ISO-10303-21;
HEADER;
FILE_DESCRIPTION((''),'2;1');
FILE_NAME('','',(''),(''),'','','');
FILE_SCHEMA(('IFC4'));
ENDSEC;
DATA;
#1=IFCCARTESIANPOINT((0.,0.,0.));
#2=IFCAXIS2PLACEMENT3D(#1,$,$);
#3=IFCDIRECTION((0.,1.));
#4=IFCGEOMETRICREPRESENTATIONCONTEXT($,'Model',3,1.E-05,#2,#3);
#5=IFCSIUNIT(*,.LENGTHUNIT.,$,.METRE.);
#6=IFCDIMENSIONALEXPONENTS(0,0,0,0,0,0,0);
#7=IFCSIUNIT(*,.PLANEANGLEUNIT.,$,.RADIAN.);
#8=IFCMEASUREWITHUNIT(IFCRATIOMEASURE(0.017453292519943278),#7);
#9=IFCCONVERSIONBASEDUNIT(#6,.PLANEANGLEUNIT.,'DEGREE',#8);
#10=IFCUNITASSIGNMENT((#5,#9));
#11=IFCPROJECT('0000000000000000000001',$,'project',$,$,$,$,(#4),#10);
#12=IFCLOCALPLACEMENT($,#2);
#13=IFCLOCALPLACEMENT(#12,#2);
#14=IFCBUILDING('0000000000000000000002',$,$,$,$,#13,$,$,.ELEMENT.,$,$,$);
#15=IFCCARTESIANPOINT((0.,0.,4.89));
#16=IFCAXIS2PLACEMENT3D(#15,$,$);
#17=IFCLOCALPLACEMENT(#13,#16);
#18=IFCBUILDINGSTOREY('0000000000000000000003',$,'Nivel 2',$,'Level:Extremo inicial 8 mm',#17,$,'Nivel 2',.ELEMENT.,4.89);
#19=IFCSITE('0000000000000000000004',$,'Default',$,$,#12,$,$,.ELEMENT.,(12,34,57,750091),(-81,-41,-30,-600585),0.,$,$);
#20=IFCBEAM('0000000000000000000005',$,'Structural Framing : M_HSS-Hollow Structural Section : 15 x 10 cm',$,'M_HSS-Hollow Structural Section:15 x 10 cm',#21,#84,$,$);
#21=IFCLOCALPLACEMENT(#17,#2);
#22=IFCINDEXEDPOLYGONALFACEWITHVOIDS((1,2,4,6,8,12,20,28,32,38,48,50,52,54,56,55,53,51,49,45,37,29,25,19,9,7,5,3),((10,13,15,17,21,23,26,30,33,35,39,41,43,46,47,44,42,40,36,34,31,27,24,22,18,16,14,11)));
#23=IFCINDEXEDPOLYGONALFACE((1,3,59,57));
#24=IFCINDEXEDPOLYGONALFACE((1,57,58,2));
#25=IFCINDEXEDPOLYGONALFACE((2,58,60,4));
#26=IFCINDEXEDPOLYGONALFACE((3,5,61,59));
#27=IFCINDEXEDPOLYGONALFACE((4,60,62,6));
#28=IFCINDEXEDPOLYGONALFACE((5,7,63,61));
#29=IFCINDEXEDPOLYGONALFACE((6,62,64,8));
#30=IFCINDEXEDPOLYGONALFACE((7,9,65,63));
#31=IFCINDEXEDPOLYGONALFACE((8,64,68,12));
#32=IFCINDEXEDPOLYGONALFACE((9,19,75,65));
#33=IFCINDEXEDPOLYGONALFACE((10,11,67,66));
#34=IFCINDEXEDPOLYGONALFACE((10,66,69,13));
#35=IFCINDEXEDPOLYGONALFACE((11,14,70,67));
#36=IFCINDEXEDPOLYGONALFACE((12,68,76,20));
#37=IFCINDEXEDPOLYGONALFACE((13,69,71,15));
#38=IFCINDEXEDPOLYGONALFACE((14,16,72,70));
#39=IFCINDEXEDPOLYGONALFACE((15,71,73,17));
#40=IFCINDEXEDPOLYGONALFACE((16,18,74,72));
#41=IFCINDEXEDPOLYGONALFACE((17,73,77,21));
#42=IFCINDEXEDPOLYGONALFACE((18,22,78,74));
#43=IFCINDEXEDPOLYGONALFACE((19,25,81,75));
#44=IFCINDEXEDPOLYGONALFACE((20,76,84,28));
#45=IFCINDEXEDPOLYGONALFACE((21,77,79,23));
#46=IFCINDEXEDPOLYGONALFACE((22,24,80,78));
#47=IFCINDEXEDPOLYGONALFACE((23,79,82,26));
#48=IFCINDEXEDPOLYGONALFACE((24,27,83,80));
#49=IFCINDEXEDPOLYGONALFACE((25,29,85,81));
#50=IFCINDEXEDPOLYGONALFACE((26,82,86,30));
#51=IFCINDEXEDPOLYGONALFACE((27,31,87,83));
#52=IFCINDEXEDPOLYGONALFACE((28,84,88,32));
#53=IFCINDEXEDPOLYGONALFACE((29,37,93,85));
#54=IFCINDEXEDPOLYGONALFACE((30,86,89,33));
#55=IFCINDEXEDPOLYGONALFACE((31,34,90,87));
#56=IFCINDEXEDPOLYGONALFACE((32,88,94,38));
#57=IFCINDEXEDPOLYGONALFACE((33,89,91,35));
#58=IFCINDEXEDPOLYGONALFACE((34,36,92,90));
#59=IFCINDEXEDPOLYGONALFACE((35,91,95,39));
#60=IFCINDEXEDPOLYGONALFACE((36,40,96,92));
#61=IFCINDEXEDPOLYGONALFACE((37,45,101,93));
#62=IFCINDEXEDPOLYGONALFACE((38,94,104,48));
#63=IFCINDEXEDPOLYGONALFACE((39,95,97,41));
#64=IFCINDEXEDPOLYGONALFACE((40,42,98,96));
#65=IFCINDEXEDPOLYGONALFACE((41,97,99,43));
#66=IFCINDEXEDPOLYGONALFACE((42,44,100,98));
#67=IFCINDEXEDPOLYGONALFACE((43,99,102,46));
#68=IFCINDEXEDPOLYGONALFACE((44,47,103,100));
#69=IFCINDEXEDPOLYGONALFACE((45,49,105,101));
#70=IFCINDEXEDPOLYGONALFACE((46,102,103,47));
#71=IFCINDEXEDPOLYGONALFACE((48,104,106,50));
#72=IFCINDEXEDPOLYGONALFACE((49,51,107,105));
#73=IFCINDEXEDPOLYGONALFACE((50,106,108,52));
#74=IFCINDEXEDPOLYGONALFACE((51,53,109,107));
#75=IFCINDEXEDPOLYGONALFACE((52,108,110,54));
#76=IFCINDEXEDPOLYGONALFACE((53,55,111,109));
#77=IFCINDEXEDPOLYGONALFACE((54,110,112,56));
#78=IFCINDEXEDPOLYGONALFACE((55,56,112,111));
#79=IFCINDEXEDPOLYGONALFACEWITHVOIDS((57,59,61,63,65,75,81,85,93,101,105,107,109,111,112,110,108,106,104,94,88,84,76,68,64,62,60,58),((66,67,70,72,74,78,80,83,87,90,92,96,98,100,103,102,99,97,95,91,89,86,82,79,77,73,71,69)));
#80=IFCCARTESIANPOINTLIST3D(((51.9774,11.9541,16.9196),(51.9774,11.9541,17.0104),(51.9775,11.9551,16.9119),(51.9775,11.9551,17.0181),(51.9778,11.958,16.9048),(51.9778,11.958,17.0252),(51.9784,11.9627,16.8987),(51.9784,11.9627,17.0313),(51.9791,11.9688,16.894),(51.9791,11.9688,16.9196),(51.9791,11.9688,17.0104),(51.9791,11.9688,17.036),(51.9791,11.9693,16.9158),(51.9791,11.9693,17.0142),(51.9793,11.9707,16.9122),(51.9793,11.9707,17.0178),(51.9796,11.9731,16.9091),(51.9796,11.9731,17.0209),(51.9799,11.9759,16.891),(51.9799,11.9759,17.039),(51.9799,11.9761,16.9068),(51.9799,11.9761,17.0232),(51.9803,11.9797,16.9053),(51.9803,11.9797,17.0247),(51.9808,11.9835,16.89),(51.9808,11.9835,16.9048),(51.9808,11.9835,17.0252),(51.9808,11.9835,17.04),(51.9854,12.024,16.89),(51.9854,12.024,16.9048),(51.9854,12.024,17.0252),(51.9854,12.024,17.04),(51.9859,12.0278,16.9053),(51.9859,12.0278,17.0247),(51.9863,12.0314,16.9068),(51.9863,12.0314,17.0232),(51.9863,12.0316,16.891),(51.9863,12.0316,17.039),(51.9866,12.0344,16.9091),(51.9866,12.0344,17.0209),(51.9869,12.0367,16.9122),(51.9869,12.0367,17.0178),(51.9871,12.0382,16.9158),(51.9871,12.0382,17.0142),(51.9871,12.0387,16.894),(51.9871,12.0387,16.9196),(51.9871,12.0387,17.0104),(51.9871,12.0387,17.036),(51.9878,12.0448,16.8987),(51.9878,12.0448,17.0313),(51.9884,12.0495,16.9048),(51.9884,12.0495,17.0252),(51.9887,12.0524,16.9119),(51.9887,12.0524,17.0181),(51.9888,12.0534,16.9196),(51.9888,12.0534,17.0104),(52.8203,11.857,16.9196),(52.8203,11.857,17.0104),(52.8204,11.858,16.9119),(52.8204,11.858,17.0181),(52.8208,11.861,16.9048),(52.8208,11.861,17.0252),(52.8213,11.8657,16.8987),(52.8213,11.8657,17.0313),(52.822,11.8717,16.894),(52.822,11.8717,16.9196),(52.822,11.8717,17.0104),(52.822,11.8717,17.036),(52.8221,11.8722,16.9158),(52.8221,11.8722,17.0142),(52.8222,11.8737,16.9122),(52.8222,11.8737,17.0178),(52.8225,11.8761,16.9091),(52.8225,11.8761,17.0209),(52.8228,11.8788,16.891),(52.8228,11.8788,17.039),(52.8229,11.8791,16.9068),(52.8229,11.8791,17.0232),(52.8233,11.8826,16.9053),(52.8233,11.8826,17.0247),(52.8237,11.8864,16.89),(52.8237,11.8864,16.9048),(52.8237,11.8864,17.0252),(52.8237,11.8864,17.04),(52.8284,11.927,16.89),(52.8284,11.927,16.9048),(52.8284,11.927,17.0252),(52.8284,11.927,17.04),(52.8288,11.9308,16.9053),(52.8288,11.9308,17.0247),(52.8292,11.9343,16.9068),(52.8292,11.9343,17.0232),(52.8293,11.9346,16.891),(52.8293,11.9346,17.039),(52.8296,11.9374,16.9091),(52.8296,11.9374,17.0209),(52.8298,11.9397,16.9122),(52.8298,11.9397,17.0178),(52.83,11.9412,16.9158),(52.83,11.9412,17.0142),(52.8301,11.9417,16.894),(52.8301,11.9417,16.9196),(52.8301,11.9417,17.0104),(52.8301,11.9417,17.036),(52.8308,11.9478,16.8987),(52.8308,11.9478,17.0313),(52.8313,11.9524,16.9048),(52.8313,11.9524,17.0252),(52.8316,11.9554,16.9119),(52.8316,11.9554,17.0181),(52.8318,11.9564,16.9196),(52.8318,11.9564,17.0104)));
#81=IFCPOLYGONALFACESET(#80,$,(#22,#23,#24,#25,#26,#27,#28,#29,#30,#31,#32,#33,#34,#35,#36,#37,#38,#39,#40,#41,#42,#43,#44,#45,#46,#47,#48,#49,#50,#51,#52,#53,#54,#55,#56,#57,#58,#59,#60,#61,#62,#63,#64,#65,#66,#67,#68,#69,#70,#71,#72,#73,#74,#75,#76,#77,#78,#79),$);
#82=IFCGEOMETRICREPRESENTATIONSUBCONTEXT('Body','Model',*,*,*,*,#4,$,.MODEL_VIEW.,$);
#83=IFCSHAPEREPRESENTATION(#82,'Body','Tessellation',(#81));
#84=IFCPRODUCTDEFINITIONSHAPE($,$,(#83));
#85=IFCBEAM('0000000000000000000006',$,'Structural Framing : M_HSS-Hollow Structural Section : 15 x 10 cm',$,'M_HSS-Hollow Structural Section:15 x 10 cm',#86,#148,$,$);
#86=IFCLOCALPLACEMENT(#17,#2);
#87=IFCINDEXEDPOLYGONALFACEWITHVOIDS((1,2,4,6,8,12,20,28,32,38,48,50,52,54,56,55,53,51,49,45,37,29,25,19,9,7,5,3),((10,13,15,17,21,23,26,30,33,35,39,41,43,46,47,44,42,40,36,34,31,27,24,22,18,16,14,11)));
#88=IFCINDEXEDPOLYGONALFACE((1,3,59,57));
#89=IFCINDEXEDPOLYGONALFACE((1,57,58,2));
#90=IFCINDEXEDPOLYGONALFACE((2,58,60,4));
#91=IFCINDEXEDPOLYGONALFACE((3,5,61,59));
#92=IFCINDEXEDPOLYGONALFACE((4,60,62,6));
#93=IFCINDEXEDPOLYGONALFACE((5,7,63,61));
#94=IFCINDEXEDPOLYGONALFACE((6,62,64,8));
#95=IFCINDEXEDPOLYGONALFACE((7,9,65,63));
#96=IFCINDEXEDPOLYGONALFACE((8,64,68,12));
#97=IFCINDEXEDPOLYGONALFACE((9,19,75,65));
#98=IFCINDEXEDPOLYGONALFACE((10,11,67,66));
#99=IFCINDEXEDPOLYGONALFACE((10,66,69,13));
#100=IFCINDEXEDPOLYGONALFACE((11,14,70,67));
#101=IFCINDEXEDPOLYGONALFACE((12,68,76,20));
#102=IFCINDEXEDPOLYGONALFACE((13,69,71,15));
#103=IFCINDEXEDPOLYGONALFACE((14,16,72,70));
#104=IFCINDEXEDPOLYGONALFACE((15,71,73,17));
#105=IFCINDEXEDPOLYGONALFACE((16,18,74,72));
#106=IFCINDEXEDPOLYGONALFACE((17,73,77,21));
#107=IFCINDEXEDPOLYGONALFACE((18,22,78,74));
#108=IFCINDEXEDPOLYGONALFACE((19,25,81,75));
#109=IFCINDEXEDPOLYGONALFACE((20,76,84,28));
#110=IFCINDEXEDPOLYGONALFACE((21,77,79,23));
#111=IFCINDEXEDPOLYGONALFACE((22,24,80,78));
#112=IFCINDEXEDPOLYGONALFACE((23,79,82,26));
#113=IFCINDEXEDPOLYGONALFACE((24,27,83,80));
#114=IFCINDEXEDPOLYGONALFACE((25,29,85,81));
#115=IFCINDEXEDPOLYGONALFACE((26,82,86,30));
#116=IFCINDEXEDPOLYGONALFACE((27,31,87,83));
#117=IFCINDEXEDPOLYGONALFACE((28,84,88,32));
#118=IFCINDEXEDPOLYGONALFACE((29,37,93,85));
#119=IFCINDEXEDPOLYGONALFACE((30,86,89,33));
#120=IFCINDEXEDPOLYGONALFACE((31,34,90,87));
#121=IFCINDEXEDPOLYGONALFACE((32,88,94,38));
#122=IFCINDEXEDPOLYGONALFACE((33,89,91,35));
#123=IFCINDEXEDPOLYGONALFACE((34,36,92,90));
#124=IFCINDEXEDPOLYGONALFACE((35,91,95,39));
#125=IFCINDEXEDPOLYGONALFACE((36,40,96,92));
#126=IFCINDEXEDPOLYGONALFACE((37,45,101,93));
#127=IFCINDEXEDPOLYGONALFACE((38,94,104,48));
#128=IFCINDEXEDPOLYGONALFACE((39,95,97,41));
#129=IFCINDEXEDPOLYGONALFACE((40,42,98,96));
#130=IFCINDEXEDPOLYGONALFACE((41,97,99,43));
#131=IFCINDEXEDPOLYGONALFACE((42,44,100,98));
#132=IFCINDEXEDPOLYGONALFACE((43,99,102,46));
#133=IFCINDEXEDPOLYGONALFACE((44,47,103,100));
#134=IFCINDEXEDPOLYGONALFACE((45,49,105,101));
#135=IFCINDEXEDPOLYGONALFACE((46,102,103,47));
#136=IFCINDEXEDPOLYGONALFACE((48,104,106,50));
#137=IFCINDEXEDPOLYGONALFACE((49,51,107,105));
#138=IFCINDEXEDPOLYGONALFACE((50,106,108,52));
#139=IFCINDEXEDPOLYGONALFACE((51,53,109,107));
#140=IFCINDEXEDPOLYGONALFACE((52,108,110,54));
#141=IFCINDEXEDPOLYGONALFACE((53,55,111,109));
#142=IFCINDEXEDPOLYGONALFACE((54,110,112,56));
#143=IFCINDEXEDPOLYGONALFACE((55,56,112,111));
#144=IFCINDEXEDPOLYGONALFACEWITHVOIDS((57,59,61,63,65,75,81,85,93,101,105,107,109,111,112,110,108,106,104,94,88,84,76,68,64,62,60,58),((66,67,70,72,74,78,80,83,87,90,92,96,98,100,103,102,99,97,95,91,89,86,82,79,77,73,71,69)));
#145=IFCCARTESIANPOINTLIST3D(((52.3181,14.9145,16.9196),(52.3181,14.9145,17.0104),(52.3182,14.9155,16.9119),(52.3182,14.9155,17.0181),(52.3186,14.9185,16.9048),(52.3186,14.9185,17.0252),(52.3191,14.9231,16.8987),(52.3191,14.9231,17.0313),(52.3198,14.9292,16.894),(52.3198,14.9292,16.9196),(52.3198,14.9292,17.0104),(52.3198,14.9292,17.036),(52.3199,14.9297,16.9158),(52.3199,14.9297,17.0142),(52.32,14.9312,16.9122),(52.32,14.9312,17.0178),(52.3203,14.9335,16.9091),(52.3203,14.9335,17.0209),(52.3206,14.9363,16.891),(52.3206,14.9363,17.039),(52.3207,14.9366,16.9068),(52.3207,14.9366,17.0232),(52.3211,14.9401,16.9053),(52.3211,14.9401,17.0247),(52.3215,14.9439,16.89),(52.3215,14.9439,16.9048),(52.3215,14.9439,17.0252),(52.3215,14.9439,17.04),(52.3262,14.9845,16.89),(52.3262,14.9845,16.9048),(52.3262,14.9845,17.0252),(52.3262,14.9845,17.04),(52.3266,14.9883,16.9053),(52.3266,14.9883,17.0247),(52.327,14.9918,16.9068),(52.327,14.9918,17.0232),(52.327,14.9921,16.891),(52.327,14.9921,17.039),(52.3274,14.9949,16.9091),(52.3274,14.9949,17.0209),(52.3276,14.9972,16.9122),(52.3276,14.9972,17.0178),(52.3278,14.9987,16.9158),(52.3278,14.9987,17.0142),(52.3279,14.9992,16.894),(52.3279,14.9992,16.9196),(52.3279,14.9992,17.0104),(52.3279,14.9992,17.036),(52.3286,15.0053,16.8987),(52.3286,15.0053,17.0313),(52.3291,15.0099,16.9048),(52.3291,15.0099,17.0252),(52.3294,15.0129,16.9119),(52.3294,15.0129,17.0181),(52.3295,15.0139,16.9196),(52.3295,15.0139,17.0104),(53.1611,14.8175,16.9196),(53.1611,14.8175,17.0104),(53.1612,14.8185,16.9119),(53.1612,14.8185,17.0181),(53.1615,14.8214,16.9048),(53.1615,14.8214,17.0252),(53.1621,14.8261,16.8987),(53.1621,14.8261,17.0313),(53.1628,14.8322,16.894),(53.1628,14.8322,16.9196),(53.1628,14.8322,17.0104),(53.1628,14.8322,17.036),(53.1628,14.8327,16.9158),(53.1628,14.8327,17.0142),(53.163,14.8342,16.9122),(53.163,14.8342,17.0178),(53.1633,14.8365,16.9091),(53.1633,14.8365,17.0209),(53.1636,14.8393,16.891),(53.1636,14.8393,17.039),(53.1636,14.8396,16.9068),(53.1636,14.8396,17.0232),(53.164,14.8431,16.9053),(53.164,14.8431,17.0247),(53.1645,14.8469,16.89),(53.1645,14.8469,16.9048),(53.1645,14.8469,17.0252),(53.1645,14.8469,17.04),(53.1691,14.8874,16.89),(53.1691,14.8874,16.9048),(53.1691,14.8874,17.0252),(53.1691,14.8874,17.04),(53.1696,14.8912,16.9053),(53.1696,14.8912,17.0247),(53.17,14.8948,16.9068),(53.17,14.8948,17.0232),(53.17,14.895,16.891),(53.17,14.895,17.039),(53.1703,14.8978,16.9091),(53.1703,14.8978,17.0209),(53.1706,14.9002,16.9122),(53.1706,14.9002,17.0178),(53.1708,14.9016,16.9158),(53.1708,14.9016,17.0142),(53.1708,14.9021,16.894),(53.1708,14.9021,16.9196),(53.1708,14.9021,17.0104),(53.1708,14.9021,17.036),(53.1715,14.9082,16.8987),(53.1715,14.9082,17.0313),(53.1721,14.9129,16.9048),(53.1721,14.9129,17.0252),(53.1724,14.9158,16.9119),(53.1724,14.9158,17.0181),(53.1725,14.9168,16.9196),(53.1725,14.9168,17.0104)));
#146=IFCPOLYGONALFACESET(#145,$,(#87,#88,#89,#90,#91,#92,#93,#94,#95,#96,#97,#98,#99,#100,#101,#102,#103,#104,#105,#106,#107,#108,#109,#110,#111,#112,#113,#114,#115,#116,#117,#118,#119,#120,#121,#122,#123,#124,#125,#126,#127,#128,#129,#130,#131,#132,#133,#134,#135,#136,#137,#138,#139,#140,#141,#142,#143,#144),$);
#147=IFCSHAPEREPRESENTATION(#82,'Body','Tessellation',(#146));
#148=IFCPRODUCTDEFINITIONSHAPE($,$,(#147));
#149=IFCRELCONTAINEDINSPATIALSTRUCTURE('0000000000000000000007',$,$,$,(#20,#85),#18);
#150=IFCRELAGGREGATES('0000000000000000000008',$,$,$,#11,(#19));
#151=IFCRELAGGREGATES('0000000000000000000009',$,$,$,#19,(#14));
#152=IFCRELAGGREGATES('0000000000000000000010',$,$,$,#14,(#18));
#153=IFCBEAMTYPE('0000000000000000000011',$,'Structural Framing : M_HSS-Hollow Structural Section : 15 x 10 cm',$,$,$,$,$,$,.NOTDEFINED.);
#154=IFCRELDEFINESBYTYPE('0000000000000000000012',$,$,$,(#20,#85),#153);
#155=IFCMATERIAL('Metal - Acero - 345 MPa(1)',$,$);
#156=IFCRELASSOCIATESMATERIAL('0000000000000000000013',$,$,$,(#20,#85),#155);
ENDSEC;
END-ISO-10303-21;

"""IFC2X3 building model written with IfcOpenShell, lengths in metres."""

from ifc_helpers import new_model, entity, si_unit, converted_unit, direction, frame, frame_2d, origin, place, context, subcontext, project, spatial, polyline, circle_curve, parameter, trimmed, segment, composite_curve, outline, extrude, material, type_object, element, save


model = new_model("IFC2X3")

# Units and contexts
model_context = context("Model", 3, precision=1e-05, world=origin(), true_north=direction((0.0, 1.0)))
body_context = subcontext(model_context, "Body", "Model", "MODEL_VIEW")
ifc_project = project(units=[si_unit("LENGTHUNIT", "METRE"), converted_unit("PLANEANGLEUNIT", "DEGREE", entity("IfcRatioMeasure", 0.017453292519943278), si_unit("PLANEANGLEUNIT", "RADIAN"), dimensions=[0, 0, 0, 0, 0, 0, 0])], contexts=[model_context])

# Site, building, storey
site_placement = place(None, origin())
site = spatial("IfcSite", under=ifc_project, at=site_placement, Name="Default", CompositionType="ELEMENT", RefLatitude=(12, 34, 57, 750091), RefLongitude=(-81, -41, -30, -600585), RefElevation=0.0)
building_placement = place(site_placement, origin())
building = spatial("IfcBuilding", under=site, at=building_placement, CompositionType="ELEMENT")
storey_placement = place(building_placement, frame((0.0, 0.0, 4.89)))
storey = spatial("IfcBuildingStorey", under=building, at=storey_placement, Name="Nivel 2", ObjectType="Level:Extremo inicial 8 mm", LongName="Nivel 2", CompositionType="ELEMENT", Elevation=4.89)

# Shared definitions
ifc_material_1 = material(Name="Metal - Acero - 345 MPa(1)")

# Beams
beam_type_1 = type_object("IfcBeamType", Name="Structural Framing : M_HSS-Hollow Structural Section : 15 x 10 cm", PredefinedType="NOTDEFINED")
beam_1_placement = place(storey_placement, frame((53.1737, 11.8667, 17.04), z_axis=(0.0, 0.0, 1.0), x_axis=(-0.993441, 0.114344, 0.0)))
element("IfcBeam", 1, at=beam_1_placement, inside=storey, type_object=beam_type_1, material=ifc_material_1, Name="Structural Framing : M_HSS-Hollow Structural Section : 15 x 10 cm", ObjectType="M_HSS-Hollow Structural Section:15 x 10 cm", context=body_context, shape_type="SweptSolid", body=[
    extrude(outline(composite_curve([segment(trimmed(circle_curve(frame_2d((-0.0204, -0.0454), x_axis=(1.0, 0.0)), 0.0296), [parameter(180.0)], [parameter(270.0)], True, "PARAMETER"), True, "CONTINUOUS"), segment(polyline([(-0.0204, -0.075), (0.0204, -0.075)]), True, "CONTINUOUS"), segment(trimmed(circle_curve(frame_2d((0.0204, -0.0454), x_axis=(1.0, 0.0)), 0.0296), [parameter(270.0)], [parameter(0.0)], True, "PARAMETER"), True, "CONTINUOUS"), segment(polyline([(0.05, -0.0454), (0.05, 0.0454)]), True, "CONTINUOUS"), segment(trimmed(circle_curve(frame_2d((0.0204, 0.0454), x_axis=(1.0, 0.0)), 0.0296), [parameter(360.0)], [parameter(90.0)], True, "PARAMETER"), True, "CONTINUOUS"), segment(polyline([(0.0204, 0.075), (-0.0204, 0.075)]), True, "CONTINUOUS"), segment(trimmed(circle_curve(frame_2d((-0.0204, 0.0454), x_axis=(1.0, 0.0)), 0.0296), [parameter(90.0)], [parameter(180.0)], True, "PARAMETER"), True, "CONTINUOUS"), segment(polyline([(-0.05, 0.0454), (-0.05, -0.0454)]), True, "CONTINUOUS")], self_intersect=False), holes=[composite_curve([segment(polyline([(0.0204, -0.0602), (-0.0204, -0.0602)]), True, "CONTINUOUS"), segment(trimmed(circle_curve(frame_2d((-0.0204, -0.0454), x_axis=(1.0, 0.0)), 0.0148), [parameter(180.0)], [parameter(270.0)], True, "PARAMETER"), False, "CONTINUOUS"), segment(polyline([(-0.0352, -0.0454), (-0.0352, 0.0454)]), True, "CONTINUOUS"), segment(trimmed(circle_curve(frame_2d((-0.0204, 0.0454), x_axis=(1.0, 0.0)), 0.0148), [parameter(90.0)], [parameter(180.0)], True, "PARAMETER"), False, "CONTINUOUS"), segment(polyline([(-0.0204, 0.0602), (0.0204, 0.0602)]), True, "CONTINUOUS"), segment(trimmed(circle_curve(frame_2d((0.0204, 0.0454), x_axis=(1.0, 0.0)), 0.0148), [parameter(0.0)], [parameter(90.0)], True, "PARAMETER"), False, "CONTINUOUS"), segment(polyline([(0.0352, 0.0454), (0.0352, -0.0454)]), True, "CONTINUOUS"), segment(trimmed(circle_curve(frame_2d((0.0204, -0.0454), x_axis=(1.0, 0.0)), 0.0148), [parameter(270.0)], [parameter(0.0)], True, "PARAMETER"), False, "CONTINUOUS")], self_intersect=False)]), frame((0.35, 0.0, -0.075), z_axis=(1.0, 0.0, 0.0), x_axis=(0.0, -1.0, 0.0)), (0.0, 0.0, 1.0), 0.8485),
])
beam_2_placement = place(storey_placement, frame((53.5145, 14.8272, 17.04), z_axis=(0.0, 0.0, 1.0), x_axis=(-0.993441, 0.114344, 0.0)))
element("IfcBeam", 2, at=beam_2_placement, inside=storey, type_object=beam_type_1, material=ifc_material_1, Name="Structural Framing : M_HSS-Hollow Structural Section : 15 x 10 cm", ObjectType="M_HSS-Hollow Structural Section:15 x 10 cm", context=body_context, shape_type="SweptSolid", body=[
    extrude(outline(composite_curve([segment(trimmed(circle_curve(frame_2d((-0.0204, -0.0454), x_axis=(1.0, 0.0)), 0.0296), [parameter(180.0)], [parameter(270.0)], True, "PARAMETER"), True, "CONTINUOUS"), segment(polyline([(-0.0204, -0.075), (0.0204, -0.075)]), True, "CONTINUOUS"), segment(trimmed(circle_curve(frame_2d((0.0204, -0.0454), x_axis=(1.0, 0.0)), 0.0296), [parameter(270.0)], [parameter(0.0)], True, "PARAMETER"), True, "CONTINUOUS"), segment(polyline([(0.05, -0.0454), (0.05, 0.0454)]), True, "CONTINUOUS"), segment(trimmed(circle_curve(frame_2d((0.0204, 0.0454), x_axis=(1.0, 0.0)), 0.0296), [parameter(360.0)], [parameter(90.0)], True, "PARAMETER"), True, "CONTINUOUS"), segment(polyline([(0.0204, 0.075), (-0.0204, 0.075)]), True, "CONTINUOUS"), segment(trimmed(circle_curve(frame_2d((-0.0204, 0.0454), x_axis=(1.0, 0.0)), 0.0296), [parameter(90.0)], [parameter(180.0)], True, "PARAMETER"), True, "CONTINUOUS"), segment(polyline([(-0.05, 0.0454), (-0.05, -0.0454)]), True, "CONTINUOUS")], self_intersect=False), holes=[composite_curve([segment(polyline([(0.0204, -0.0602), (-0.0204, -0.0602)]), True, "CONTINUOUS"), segment(trimmed(circle_curve(frame_2d((-0.0204, -0.0454), x_axis=(1.0, 0.0)), 0.0148), [parameter(180.0)], [parameter(270.0)], True, "PARAMETER"), False, "CONTINUOUS"), segment(polyline([(-0.0352, -0.0454), (-0.0352, 0.0454)]), True, "CONTINUOUS"), segment(trimmed(circle_curve(frame_2d((-0.0204, 0.0454), x_axis=(1.0, 0.0)), 0.0148), [parameter(90.0)], [parameter(180.0)], True, "PARAMETER"), False, "CONTINUOUS"), segment(polyline([(-0.0204, 0.0602), (0.0204, 0.0602)]), True, "CONTINUOUS"), segment(trimmed(circle_curve(frame_2d((0.0204, 0.0454), x_axis=(1.0, 0.0)), 0.0148), [parameter(0.0)], [parameter(90.0)], True, "PARAMETER"), False, "CONTINUOUS"), segment(polyline([(0.0352, 0.0454), (0.0352, -0.0454)]), True, "CONTINUOUS"), segment(trimmed(circle_curve(frame_2d((0.0204, -0.0454), x_axis=(1.0, 0.0)), 0.0148), [parameter(270.0)], [parameter(0.0)], True, "PARAMETER"), False, "CONTINUOUS")], self_intersect=False)]), frame((0.35, 0.0, -0.075), z_axis=(1.0, 0.0, 0.0), x_axis=(0.0, -1.0, 0.0)), (0.0, 0.0, 1.0), 0.8485),
])

save(model, "model.ifc")
